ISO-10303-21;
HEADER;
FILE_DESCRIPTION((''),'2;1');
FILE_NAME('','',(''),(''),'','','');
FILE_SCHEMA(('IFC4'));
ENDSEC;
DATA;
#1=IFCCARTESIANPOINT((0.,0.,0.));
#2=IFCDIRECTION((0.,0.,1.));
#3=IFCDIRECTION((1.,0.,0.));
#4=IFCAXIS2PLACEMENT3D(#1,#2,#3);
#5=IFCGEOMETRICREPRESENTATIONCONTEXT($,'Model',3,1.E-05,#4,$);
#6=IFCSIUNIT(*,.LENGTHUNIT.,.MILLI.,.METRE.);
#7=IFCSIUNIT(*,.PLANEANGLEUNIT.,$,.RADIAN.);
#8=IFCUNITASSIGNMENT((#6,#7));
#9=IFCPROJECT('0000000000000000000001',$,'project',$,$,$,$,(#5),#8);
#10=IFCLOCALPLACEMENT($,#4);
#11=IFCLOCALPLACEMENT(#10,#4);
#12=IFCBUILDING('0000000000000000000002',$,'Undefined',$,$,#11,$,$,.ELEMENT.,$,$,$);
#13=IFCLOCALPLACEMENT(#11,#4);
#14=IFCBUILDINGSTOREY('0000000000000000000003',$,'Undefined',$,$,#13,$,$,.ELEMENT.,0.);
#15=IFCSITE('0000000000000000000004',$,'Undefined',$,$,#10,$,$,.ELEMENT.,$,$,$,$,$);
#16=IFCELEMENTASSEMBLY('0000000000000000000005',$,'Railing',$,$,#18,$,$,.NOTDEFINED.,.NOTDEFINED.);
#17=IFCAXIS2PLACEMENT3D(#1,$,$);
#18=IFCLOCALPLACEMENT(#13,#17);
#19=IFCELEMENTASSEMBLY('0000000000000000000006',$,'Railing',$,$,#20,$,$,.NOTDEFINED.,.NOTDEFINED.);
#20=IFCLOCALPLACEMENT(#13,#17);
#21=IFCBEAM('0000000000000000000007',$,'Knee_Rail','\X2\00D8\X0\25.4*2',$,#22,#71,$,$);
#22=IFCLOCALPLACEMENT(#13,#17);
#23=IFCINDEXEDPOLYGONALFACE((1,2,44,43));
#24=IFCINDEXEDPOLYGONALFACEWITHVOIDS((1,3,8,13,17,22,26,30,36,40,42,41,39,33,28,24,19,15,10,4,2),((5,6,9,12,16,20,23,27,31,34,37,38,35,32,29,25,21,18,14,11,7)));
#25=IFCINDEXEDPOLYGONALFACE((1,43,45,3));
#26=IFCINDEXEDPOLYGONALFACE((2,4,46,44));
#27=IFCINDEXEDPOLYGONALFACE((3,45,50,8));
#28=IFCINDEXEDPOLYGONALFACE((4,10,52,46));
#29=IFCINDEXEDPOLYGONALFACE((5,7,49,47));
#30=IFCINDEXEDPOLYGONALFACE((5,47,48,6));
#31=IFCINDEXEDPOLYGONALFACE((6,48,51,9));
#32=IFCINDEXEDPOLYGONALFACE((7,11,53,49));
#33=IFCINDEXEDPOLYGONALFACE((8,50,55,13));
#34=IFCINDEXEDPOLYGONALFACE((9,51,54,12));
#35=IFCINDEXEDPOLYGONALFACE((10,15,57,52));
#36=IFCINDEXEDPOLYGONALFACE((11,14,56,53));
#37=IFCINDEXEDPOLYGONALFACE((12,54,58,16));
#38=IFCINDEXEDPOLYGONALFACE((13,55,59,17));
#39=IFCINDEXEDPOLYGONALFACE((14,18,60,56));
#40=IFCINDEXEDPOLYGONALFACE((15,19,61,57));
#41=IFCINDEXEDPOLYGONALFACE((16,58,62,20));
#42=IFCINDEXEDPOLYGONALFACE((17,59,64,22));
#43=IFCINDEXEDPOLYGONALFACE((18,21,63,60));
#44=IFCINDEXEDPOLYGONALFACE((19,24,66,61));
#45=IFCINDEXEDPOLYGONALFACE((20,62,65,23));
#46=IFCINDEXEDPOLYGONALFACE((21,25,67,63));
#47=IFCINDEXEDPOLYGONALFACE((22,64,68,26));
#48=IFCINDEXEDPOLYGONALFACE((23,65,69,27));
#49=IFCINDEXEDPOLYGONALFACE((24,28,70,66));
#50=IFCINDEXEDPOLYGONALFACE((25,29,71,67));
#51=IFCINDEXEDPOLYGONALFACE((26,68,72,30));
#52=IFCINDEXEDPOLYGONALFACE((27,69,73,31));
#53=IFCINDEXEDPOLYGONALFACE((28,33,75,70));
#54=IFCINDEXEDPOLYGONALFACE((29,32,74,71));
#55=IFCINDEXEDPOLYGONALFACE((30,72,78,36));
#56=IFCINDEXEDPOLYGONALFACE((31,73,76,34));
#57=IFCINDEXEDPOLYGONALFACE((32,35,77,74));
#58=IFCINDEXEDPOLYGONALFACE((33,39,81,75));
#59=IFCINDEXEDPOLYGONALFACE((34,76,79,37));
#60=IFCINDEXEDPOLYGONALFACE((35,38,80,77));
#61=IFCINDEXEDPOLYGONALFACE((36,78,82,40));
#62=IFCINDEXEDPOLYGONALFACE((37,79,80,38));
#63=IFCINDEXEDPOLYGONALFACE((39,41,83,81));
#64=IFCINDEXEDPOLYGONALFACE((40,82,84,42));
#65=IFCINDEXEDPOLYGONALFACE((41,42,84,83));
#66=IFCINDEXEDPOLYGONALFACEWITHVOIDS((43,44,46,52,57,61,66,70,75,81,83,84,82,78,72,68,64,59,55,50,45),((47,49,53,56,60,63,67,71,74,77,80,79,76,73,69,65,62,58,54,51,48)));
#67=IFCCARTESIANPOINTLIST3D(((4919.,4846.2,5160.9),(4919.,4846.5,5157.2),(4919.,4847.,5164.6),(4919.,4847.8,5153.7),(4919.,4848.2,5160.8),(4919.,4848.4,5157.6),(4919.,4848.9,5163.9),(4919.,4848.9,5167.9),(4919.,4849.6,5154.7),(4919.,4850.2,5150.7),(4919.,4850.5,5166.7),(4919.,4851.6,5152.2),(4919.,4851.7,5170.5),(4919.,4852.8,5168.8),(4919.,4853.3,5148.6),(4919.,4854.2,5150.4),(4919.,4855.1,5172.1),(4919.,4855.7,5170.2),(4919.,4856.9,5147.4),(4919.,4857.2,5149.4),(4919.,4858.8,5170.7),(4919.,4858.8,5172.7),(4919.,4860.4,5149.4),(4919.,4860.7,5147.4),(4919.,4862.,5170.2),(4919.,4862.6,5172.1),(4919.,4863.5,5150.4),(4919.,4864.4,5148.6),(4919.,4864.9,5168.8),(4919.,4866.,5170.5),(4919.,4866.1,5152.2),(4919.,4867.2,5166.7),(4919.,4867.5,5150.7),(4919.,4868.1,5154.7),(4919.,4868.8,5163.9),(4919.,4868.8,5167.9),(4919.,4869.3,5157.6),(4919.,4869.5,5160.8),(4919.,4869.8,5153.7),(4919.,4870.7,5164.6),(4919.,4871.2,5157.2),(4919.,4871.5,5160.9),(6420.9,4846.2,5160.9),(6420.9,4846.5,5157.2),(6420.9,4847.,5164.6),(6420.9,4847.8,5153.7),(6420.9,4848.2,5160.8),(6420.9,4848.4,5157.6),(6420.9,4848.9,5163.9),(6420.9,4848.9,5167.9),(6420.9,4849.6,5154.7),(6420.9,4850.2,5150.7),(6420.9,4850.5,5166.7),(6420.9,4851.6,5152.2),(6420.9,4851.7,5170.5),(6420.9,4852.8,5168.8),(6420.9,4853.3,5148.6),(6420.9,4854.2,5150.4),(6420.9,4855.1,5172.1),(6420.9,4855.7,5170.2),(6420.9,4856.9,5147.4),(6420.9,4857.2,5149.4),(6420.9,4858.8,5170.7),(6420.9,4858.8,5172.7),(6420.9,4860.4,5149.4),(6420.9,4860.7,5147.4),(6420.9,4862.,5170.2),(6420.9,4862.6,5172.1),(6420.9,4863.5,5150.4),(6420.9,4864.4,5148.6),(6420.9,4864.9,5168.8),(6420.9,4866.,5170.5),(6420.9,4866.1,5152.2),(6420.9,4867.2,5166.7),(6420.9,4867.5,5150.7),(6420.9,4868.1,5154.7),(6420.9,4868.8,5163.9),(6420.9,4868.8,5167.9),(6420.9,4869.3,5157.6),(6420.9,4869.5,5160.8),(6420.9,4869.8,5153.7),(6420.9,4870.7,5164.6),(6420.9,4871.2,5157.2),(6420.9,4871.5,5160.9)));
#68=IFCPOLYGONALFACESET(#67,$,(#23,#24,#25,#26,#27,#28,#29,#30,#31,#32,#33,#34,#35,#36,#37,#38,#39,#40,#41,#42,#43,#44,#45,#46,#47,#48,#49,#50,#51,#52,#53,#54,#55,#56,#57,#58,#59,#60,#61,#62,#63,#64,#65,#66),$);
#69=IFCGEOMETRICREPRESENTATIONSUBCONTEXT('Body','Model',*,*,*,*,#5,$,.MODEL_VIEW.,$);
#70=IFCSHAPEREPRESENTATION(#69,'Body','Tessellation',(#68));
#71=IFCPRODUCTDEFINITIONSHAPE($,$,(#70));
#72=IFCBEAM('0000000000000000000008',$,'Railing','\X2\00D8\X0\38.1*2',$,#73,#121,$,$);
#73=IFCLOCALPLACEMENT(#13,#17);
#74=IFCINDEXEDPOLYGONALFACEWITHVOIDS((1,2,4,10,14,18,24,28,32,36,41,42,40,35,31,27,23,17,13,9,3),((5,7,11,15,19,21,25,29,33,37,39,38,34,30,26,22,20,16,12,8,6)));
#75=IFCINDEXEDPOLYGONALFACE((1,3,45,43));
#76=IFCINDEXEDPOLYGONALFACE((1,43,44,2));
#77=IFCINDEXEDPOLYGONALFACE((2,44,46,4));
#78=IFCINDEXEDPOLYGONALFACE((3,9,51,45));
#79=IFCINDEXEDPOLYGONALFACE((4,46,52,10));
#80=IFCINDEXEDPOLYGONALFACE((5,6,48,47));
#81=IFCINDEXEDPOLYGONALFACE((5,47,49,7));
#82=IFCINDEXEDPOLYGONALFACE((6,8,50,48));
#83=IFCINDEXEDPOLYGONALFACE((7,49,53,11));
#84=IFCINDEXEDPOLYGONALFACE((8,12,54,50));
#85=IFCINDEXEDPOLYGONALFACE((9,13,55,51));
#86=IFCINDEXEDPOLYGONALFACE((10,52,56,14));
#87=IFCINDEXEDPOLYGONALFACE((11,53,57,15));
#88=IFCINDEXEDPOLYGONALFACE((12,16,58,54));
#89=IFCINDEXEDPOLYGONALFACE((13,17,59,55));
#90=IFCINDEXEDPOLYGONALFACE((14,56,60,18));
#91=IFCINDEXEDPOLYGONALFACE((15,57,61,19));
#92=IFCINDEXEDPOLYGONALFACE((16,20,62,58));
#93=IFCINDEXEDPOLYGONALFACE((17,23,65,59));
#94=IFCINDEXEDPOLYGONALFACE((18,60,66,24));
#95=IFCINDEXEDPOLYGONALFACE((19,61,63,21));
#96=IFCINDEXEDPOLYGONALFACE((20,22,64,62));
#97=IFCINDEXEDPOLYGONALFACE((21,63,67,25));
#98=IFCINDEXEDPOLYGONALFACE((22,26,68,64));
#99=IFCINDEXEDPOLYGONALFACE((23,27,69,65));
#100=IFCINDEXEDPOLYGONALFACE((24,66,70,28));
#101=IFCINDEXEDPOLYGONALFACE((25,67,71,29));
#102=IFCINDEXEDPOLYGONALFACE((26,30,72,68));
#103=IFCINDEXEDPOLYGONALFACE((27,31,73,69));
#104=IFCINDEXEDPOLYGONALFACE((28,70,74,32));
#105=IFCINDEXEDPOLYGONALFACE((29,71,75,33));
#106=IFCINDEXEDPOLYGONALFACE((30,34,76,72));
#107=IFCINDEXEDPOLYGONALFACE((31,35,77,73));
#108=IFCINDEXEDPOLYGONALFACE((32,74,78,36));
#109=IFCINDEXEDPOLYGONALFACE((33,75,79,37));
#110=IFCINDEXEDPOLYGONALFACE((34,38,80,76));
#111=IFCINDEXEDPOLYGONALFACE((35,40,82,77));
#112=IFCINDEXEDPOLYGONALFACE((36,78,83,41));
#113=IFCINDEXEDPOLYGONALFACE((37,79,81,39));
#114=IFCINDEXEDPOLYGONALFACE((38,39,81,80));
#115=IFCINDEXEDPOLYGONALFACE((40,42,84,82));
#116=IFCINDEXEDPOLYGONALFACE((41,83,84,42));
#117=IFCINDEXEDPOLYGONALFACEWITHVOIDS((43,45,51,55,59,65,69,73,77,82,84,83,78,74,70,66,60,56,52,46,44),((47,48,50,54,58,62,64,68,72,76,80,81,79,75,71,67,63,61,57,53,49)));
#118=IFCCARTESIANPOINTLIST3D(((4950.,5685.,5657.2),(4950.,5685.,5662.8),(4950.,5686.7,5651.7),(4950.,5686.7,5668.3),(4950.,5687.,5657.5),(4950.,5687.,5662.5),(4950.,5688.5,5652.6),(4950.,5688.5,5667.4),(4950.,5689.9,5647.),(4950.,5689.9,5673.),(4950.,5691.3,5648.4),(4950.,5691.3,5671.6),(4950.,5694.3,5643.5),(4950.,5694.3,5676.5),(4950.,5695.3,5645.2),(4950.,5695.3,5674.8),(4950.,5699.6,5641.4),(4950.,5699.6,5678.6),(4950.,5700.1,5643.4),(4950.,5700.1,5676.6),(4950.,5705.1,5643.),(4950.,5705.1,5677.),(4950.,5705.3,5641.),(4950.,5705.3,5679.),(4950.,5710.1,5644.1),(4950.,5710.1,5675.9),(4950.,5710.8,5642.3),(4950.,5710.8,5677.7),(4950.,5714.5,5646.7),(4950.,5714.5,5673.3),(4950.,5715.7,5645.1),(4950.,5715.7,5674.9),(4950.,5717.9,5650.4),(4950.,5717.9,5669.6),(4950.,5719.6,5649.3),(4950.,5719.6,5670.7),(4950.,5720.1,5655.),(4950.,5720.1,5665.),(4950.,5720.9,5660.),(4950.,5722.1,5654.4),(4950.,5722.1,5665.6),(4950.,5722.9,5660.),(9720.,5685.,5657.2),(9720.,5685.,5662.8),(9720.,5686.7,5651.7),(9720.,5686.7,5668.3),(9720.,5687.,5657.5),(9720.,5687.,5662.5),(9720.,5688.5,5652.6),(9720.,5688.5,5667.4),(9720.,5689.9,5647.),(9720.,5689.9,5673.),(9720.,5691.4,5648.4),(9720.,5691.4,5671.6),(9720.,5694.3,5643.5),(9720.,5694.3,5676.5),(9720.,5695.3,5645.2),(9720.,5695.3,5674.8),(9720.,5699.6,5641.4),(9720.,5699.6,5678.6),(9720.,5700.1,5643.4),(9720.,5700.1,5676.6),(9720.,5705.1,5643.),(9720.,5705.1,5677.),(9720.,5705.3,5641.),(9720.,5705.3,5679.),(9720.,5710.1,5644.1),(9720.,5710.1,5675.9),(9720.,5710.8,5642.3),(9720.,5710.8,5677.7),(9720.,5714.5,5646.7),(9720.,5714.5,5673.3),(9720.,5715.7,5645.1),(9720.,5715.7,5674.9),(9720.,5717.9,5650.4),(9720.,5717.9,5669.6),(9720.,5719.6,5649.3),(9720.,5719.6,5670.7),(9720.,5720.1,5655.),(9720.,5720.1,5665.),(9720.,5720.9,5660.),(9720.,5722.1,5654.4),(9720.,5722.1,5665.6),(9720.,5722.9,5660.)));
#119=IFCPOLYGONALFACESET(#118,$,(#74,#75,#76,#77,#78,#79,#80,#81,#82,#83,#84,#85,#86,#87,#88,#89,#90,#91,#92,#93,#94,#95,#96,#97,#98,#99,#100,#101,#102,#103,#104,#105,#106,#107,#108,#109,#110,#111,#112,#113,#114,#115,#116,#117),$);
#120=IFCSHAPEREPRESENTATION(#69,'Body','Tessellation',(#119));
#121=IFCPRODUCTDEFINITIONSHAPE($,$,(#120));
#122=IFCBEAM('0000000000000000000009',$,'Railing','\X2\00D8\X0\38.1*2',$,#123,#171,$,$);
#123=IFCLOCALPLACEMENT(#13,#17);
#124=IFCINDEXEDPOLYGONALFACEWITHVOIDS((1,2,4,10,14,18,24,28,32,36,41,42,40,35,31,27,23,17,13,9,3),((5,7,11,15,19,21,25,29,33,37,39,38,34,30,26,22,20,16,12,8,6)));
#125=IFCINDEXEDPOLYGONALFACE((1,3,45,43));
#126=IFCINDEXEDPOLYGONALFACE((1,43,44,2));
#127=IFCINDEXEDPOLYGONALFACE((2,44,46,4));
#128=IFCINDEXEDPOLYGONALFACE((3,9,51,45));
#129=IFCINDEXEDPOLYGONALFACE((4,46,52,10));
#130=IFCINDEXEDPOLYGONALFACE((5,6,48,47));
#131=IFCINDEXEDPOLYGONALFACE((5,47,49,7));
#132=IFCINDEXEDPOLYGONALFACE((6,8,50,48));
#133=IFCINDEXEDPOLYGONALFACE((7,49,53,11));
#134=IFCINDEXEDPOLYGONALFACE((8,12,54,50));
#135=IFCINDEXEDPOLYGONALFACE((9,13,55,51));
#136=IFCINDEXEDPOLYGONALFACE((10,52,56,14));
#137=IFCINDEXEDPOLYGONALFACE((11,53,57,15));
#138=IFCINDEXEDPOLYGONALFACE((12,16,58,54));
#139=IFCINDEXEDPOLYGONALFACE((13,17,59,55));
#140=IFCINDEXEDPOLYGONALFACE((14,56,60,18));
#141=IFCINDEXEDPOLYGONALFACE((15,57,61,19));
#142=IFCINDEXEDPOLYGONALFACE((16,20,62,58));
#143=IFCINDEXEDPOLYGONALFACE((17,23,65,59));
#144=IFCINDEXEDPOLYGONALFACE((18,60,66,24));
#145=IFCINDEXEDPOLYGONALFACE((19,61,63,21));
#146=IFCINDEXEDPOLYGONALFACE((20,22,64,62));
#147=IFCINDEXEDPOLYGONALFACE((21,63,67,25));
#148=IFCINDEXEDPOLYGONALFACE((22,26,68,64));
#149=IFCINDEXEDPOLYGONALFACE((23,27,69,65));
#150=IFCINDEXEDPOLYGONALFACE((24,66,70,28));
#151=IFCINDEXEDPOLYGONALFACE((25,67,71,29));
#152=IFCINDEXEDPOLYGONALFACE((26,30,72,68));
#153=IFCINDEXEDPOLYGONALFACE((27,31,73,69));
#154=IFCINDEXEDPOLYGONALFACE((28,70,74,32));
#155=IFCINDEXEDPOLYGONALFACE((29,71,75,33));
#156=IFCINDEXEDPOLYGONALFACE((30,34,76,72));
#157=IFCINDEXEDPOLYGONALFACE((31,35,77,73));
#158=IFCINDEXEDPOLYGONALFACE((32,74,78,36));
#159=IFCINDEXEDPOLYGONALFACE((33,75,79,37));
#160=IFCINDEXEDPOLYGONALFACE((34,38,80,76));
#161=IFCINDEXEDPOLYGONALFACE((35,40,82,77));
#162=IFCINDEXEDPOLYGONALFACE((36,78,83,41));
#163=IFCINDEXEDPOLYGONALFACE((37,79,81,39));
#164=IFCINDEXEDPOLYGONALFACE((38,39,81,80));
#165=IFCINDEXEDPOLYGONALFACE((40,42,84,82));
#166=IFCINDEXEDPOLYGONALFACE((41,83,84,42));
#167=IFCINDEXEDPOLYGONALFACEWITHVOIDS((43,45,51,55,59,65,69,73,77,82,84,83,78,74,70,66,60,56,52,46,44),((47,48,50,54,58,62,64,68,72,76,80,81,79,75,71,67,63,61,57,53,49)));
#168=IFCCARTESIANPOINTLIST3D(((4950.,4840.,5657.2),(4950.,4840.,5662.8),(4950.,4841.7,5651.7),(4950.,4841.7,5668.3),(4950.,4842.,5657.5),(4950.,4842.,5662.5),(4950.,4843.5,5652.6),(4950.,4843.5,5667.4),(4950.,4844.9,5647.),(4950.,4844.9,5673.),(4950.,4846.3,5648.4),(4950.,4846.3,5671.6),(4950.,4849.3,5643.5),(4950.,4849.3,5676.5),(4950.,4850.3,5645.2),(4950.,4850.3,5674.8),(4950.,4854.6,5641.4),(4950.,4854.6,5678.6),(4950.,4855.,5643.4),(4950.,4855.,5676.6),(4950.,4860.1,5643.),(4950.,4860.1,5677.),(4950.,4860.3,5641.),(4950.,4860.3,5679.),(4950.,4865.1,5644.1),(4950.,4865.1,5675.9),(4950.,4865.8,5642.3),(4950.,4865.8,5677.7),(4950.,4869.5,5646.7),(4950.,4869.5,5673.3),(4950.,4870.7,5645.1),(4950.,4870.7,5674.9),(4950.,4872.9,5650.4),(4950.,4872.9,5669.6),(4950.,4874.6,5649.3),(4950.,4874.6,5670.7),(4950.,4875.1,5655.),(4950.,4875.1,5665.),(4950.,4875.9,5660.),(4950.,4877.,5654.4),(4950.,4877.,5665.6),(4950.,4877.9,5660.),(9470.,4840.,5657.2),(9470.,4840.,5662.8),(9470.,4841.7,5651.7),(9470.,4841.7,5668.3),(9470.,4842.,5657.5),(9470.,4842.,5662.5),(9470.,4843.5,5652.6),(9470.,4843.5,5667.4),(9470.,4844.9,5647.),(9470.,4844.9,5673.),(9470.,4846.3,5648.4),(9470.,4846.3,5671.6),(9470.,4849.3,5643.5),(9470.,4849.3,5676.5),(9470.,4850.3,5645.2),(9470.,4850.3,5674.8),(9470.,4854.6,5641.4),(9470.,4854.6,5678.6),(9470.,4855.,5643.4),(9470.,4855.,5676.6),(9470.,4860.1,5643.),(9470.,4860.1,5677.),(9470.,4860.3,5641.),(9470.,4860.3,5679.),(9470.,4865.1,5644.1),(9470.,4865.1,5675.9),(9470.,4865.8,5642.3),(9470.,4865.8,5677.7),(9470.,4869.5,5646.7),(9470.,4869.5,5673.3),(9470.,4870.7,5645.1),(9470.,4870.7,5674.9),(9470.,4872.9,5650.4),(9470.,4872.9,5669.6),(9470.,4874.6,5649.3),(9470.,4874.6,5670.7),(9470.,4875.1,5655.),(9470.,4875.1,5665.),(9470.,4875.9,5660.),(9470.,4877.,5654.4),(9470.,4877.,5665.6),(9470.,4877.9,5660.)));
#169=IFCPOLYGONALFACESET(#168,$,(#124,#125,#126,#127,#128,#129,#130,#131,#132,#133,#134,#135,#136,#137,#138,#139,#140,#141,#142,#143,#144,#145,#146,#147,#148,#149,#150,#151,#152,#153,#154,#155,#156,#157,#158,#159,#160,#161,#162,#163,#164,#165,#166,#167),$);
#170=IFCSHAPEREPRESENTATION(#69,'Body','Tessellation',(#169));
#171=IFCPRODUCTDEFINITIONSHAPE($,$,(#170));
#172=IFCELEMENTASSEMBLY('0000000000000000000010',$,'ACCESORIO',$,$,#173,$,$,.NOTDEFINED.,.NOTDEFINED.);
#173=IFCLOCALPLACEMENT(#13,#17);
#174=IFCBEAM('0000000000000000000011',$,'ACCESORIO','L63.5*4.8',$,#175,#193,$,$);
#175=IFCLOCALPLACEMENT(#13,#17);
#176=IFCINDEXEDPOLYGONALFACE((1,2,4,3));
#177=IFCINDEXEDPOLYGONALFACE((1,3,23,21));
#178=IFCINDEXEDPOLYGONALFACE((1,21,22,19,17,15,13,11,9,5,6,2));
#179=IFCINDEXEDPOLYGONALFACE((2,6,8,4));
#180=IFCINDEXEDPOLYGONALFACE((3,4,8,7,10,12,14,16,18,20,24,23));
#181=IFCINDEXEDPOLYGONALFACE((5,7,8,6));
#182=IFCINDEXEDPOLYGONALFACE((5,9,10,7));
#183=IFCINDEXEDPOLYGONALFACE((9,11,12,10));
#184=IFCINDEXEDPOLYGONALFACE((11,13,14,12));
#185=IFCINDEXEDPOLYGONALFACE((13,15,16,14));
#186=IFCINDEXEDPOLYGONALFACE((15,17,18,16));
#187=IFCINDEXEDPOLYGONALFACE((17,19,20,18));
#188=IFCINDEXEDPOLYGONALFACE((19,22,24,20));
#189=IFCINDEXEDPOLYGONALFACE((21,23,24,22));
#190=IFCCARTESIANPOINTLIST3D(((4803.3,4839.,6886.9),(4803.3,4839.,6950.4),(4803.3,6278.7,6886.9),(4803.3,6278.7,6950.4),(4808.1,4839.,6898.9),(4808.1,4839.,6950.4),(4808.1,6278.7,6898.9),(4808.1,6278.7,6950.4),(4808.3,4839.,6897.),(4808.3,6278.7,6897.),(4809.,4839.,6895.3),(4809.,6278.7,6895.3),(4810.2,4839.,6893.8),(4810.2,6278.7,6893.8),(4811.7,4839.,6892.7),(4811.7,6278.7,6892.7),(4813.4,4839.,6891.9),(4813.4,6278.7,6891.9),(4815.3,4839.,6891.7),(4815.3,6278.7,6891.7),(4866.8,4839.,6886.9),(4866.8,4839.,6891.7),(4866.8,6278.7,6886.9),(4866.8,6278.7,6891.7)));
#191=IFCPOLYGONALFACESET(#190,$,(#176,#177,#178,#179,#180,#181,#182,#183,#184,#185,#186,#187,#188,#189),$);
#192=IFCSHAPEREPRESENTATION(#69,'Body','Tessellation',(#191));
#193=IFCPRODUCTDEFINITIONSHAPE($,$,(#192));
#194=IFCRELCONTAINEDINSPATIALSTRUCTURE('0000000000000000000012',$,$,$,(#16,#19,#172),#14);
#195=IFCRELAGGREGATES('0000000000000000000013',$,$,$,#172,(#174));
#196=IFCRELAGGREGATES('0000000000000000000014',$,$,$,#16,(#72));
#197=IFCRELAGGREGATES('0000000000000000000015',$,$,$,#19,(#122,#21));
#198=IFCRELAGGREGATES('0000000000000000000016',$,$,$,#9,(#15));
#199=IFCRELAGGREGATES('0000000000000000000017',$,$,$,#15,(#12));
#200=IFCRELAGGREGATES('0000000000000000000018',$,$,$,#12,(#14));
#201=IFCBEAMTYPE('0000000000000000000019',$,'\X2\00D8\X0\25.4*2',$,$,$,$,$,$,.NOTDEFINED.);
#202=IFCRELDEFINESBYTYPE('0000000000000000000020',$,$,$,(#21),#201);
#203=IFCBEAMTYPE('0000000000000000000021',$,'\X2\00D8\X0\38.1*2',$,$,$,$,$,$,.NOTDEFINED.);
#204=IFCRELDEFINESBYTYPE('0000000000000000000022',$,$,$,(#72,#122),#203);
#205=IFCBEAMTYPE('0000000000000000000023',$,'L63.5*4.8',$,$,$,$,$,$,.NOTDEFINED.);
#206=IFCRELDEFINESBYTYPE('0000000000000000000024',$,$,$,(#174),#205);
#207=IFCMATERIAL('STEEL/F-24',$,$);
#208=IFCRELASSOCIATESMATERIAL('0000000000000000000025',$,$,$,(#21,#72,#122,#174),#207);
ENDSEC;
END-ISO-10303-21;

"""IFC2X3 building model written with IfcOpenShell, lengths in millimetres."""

from ifc_helpers import new_model, si_unit, frame, origin_with_axes, origin_2d_with_axis, place, context, subcontext, project, spatial, hollow_circle, l_section, extrude, material, type_object, element, aggregate, save


model = new_model("IFC2X3")

# Units and contexts
model_context = context("Model", 3, precision=1e-05, world=origin_with_axes())
body_context = subcontext(model_context, "Body", "Model", "MODEL_VIEW")
ifc_project = project(units=[si_unit("LENGTHUNIT", "METRE", prefix="MILLI"), si_unit("PLANEANGLEUNIT", "RADIAN")], contexts=[model_context])

# Site, building, storey
site_placement = place(None, origin_with_axes())
site = spatial("IfcSite", under=ifc_project, at=site_placement, Name="Undefined", CompositionType="ELEMENT")
building_placement = place(site_placement, origin_with_axes())
building = spatial("IfcBuilding", under=site, at=building_placement, Name="Undefined", CompositionType="ELEMENT")
storey_placement = place(building_placement, origin_with_axes())
storey = spatial("IfcBuildingStorey", under=building, at=storey_placement, Name="Undefined", CompositionType="ELEMENT", Elevation=0.0)

# Element assemblies, beam
assembly_1_placement = place(storey_placement, origin_with_axes())
assembly_1 = element("IfcElementAssembly", 1, at=assembly_1_placement, inside=storey, Name="Railing", AssemblyPlace="NOTDEFINED", PredefinedType="NOTDEFINED")
ifc_material_1 = material(Name="STEEL/F-24")
beam_type_1 = type_object("IfcBeamType", Name="Ø25.4*2", PredefinedType="NOTDEFINED")
assembly_2_placement = place(storey_placement, origin_with_axes())
assembly_2 = element("IfcElementAssembly", 2, at=assembly_2_placement, inside=storey, Name="Railing", AssemblyPlace="NOTDEFINED", PredefinedType="NOTDEFINED")
beam_1_placement = place(assembly_2_placement, frame((4919.0, 4858.8, 5160.0), z_axis=(0.0, 1.0, 0.0), x_axis=(1.0, 0.0, 0.0)))
beam_1 = element("IfcBeam", 3, at=beam_1_placement, type_object=beam_type_1, material=ifc_material_1, Name="Knee_Rail", Description="Ø25.4*2", context=body_context, shape_type="SweptSolid", body=[
    extrude(hollow_circle(Radius=12.7, WallThickness=2.0, at=origin_2d_with_axis()), frame((1501.9, 0.0, 0.0), z_axis=(-1.0, 0.0, 0.0), x_axis=(0.0, -1.0, 0.0)), (0.0, 0.0, 1.0), 1501.9),
])

# Beams
beam_type_2 = type_object("IfcBeamType", Name="Ø38.1*2", PredefinedType="NOTDEFINED")
beam_2_placement = place(assembly_1_placement, frame((4950.0, 5703.8, 5660.0), z_axis=(0.0, 0.0, -1.0), x_axis=(1.0, 0.000002, 0.0)))
beam_2 = element("IfcBeam", 4, at=beam_2_placement, type_object=beam_type_2, material=ifc_material_1, Name="Railing", Description="Ø38.1*2", context=body_context, shape_type="SweptSolid", body=[
    extrude(hollow_circle(Radius=19.1, WallThickness=2.0, at=origin_2d_with_axis()), frame((4770.0, 0.0, 0.0), z_axis=(-1.0, 0.0, 0.0), x_axis=(0.0, -1.0, 0.0)), (0.0, 0.0, 1.0), 4770.0),
])
beam_3_placement = place(assembly_2_placement, frame((4950.0, 4858.8, 5660.0), z_axis=(0.0, 0.0, -1.0), x_axis=(1.0, 0.0, 0.0)))
beam_3 = element("IfcBeam", 5, at=beam_3_placement, type_object=beam_type_2, material=ifc_material_1, Name="Railing", Description="Ø38.1*2", context=body_context, shape_type="SweptSolid", body=[
    extrude(hollow_circle(Radius=19.1, WallThickness=2.0, at=origin_2d_with_axis()), frame((4520.0, 0.0, 0.0), z_axis=(-1.0, 0.0, 0.0), x_axis=(0.0, -1.0, 0.0)), (0.0, 0.0, 1.0), 4520.0),
])

# Element assembly, beam
assembly_3_placement = place(storey_placement, origin_with_axes())
assembly_3 = element("IfcElementAssembly", 6, at=assembly_3_placement, inside=storey, Name="ACCESORIO", AssemblyPlace="NOTDEFINED", PredefinedType="NOTDEFINED")
beam_type_3 = type_object("IfcBeamType", Name="L63.5*4.8", PredefinedType="NOTDEFINED")
beam_4_placement = place(assembly_3_placement, frame((4835.0, 6278.7, 6918.6), z_axis=(1.0, 0.0, 0.0), x_axis=(0.0, -1.0, 0.0)))
beam_4 = element("IfcBeam", 7, at=beam_4_placement, type_object=beam_type_3, material=ifc_material_1, Name="ACCESORIO", Description="L63.5*4.8", context=body_context, shape_type="SweptSolid", body=[
    extrude(l_section(Depth=63.5, Width=63.5, Thickness=4.8, FilletRadius=7.2, at=origin_2d_with_axis()), frame((1439.7, 0.0, 0.0), z_axis=(-1.0, 0.0, 0.0), x_axis=(0.0, -1.0, 0.0)), (0.0, 0.0, 1.0), 1439.7),
])
aggregate(assembly_3, [beam_4])

aggregate(assembly_1, [beam_2])
aggregate(assembly_2, [beam_3, beam_1])

save(model, "model.ifc")
